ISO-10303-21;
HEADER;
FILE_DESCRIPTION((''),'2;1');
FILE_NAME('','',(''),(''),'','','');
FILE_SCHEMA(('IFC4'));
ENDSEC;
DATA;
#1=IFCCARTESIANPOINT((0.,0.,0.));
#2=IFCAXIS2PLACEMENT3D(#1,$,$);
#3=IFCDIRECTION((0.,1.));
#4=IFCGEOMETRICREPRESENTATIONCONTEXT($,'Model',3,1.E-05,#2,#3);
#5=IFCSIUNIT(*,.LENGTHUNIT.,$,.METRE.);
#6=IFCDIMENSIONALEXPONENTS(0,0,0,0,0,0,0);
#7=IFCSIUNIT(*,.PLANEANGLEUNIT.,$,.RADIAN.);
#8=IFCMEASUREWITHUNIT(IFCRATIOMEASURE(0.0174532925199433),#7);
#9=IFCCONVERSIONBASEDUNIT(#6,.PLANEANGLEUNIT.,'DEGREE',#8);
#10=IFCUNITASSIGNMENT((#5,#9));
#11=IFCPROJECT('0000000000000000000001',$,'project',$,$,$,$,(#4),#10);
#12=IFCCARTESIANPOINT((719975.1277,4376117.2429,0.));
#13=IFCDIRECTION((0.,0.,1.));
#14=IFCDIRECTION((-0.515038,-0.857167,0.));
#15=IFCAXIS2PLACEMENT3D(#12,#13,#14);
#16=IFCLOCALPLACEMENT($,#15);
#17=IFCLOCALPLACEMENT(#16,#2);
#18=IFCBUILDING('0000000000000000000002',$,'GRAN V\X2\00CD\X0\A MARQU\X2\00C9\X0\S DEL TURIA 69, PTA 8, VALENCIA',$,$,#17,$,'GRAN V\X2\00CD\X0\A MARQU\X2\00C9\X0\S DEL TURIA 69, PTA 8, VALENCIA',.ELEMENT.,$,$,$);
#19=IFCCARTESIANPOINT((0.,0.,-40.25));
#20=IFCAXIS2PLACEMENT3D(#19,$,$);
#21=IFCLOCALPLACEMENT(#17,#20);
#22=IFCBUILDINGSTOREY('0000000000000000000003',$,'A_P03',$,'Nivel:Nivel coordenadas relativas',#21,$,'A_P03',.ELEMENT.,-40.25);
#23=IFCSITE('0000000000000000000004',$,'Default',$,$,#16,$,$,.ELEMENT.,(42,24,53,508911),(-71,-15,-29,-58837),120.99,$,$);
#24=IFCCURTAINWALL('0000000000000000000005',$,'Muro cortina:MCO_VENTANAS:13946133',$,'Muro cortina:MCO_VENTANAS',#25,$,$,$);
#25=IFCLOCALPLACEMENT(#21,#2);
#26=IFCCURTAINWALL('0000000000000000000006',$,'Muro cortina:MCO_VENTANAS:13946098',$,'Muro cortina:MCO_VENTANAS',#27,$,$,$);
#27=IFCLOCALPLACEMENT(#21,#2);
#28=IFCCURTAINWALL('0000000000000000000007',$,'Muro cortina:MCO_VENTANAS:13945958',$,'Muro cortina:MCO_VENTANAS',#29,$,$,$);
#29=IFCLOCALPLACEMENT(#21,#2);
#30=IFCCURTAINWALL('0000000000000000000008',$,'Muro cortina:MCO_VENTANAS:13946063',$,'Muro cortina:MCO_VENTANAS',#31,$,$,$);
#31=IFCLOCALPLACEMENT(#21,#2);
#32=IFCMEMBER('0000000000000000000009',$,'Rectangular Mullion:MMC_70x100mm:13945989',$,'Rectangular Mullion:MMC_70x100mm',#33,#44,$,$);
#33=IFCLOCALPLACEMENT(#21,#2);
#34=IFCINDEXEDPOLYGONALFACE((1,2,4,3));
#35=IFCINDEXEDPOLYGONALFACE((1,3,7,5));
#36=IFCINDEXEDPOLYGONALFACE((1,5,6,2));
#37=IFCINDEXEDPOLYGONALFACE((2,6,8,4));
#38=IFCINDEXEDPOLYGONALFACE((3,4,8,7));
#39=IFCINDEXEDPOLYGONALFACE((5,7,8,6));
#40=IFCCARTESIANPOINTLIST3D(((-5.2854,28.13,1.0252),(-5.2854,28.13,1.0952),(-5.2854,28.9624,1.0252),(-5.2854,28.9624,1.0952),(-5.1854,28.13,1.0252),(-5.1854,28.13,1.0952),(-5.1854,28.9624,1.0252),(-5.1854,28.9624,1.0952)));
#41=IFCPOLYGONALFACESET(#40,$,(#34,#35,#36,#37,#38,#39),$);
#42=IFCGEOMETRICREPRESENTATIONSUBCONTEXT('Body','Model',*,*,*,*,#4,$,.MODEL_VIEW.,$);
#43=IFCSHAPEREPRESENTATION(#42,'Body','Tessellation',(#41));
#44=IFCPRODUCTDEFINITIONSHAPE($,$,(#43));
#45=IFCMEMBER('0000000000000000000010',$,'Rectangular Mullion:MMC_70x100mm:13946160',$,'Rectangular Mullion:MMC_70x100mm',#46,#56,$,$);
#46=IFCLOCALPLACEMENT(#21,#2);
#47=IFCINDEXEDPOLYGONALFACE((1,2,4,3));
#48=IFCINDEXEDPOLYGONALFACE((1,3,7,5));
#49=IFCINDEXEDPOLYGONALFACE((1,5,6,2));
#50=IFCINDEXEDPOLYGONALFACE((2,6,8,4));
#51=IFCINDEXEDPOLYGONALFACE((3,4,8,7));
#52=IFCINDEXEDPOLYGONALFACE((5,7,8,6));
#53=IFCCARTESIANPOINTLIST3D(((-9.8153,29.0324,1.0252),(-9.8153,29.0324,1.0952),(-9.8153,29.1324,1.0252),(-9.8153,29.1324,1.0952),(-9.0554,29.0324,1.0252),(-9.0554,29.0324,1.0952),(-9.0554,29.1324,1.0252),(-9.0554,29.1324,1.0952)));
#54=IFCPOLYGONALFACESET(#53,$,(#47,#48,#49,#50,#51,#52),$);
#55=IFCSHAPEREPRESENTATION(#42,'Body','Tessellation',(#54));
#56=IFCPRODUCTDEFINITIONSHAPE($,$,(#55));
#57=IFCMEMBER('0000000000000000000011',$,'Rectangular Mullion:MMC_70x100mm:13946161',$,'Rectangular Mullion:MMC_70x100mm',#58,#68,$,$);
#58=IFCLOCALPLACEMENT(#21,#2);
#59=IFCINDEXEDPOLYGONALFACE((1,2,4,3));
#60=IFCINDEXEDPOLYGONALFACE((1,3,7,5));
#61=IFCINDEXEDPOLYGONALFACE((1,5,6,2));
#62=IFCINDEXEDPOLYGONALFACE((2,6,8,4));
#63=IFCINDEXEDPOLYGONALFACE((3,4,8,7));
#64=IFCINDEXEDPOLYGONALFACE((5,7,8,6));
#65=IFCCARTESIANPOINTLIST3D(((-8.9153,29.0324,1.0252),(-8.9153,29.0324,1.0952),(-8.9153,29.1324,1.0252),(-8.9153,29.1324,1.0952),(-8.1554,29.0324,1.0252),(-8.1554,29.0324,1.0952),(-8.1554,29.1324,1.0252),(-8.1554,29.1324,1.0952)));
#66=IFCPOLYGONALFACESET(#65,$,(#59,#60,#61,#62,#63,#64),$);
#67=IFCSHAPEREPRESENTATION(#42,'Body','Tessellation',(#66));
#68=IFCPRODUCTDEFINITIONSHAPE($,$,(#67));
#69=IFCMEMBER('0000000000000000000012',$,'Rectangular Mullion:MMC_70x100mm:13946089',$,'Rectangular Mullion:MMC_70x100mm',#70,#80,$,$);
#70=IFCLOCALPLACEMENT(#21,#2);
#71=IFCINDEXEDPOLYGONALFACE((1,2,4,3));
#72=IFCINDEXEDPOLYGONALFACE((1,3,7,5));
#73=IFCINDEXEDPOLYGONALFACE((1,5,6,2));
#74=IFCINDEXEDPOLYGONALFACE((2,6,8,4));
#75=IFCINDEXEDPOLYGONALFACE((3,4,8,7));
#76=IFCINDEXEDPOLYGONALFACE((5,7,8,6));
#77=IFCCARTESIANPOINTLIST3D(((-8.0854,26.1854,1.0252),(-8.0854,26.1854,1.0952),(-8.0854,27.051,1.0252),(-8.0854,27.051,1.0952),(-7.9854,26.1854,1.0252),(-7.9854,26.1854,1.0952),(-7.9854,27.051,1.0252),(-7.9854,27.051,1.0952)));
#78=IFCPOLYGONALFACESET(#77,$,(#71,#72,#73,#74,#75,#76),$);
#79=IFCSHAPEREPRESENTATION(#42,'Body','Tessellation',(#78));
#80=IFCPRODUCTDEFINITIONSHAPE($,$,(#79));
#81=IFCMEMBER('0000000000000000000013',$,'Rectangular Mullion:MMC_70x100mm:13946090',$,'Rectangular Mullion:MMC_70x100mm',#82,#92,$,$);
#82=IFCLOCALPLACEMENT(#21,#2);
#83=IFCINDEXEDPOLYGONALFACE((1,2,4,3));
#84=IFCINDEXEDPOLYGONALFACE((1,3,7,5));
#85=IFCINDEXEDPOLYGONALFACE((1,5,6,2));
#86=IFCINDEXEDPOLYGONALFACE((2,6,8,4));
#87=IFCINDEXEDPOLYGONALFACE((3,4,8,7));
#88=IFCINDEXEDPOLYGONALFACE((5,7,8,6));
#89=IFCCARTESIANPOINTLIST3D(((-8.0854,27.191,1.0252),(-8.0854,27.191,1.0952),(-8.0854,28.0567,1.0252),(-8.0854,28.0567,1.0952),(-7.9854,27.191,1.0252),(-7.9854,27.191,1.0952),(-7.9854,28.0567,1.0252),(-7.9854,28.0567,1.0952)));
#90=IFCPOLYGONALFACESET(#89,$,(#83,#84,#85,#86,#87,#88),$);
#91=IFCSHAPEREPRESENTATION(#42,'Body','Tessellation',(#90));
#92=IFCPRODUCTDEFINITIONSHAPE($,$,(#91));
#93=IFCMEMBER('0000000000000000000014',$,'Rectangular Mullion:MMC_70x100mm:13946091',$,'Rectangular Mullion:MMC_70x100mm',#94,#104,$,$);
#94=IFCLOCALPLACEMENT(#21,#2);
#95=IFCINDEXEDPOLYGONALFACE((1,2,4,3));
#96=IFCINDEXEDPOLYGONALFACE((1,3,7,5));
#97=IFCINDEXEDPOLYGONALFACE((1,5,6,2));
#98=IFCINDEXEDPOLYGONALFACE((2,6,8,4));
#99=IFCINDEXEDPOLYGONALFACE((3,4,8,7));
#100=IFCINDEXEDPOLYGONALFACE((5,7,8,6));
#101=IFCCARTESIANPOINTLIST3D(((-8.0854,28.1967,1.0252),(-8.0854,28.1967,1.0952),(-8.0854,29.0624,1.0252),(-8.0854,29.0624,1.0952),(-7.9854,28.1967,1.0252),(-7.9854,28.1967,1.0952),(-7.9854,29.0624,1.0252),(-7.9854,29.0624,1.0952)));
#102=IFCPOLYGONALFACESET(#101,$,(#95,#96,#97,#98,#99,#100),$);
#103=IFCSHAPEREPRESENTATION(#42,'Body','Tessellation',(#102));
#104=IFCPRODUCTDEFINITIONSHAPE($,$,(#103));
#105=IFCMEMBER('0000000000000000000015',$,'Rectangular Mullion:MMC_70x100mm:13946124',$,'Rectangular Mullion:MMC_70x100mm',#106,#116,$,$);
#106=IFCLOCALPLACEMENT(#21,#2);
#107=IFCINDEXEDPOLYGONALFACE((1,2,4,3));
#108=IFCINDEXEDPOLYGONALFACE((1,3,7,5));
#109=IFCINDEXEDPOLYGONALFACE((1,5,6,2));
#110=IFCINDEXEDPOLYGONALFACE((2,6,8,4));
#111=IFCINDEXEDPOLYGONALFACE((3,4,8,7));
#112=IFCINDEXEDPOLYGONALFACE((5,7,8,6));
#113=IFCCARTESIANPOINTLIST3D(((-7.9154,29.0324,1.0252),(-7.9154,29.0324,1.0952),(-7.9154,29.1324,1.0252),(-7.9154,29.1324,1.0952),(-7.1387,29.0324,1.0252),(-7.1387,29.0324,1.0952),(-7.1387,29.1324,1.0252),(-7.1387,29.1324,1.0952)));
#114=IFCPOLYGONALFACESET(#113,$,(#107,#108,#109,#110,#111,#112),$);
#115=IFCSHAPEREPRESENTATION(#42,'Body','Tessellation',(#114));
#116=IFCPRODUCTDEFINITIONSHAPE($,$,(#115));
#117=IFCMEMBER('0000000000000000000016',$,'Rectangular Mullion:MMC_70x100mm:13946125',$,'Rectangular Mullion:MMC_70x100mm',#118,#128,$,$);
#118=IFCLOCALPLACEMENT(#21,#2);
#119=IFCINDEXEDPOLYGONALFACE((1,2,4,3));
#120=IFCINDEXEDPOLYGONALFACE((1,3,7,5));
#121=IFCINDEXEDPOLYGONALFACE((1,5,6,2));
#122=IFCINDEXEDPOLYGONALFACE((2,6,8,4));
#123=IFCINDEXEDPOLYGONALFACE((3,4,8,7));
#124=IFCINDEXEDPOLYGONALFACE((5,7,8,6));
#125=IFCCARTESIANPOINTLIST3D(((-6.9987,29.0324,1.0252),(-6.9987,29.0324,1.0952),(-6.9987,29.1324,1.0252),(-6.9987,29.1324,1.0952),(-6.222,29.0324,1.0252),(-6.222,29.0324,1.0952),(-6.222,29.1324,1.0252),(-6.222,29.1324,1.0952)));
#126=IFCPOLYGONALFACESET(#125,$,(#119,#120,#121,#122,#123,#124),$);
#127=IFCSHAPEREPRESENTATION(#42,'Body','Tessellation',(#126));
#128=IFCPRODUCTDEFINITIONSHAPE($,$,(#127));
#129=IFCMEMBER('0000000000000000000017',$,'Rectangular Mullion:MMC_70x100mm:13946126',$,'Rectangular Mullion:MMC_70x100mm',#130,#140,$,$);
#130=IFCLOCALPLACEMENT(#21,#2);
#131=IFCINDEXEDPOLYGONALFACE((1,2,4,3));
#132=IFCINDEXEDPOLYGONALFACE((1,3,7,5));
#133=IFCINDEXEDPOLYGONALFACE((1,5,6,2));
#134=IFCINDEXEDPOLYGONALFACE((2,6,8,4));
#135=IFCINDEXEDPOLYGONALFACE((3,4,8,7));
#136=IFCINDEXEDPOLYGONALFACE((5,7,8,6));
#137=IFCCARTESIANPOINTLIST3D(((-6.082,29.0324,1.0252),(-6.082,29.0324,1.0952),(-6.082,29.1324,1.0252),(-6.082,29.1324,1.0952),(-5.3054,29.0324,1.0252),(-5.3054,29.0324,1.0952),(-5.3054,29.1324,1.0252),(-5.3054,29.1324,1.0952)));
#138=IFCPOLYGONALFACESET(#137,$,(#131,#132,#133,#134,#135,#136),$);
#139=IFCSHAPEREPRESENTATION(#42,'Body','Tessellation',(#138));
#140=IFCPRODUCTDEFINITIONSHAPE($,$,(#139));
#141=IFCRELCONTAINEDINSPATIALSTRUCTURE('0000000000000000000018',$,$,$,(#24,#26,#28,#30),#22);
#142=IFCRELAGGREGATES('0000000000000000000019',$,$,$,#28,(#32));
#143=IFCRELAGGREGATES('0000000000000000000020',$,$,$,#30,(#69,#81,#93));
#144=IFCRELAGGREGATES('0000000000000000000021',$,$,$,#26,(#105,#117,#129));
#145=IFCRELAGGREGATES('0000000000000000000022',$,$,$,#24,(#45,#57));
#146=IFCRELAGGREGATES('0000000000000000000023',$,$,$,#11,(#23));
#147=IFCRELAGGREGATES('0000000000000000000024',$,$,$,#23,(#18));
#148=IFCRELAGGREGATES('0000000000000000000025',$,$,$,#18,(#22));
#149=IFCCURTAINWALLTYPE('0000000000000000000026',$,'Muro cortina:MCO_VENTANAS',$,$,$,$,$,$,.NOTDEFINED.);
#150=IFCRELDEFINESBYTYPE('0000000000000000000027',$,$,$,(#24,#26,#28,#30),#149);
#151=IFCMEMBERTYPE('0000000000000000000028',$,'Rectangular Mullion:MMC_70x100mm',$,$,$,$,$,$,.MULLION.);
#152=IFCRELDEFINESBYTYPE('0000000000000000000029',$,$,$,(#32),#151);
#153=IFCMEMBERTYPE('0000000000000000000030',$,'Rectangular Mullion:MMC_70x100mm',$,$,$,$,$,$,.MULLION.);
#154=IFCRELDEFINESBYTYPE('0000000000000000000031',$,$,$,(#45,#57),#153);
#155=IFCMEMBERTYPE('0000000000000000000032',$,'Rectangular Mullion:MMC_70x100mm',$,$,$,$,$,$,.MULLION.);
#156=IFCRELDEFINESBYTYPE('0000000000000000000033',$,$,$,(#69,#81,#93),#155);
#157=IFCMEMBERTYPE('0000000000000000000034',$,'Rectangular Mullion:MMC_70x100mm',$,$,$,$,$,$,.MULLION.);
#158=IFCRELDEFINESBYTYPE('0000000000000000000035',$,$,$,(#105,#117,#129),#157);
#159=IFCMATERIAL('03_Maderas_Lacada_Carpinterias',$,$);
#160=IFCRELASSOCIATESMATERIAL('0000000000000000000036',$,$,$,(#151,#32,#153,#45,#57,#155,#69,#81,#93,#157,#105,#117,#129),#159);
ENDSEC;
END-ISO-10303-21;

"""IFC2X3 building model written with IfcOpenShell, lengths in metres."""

from ifc_helpers import new_model, entity, si_unit, converted_unit, direction, frame, origin, origin_2d_with_axis, place, context, subcontext, project, spatial, rectangle, extrude, source, transform, mapped, material, type_object, type_shapes, element, aggregate, save


model = new_model("IFC2X3")

# Units and contexts
model_context = context("Model", 3, precision=1e-05, world=origin(), true_north=direction((0.0, 1.0)))
body_context = subcontext(model_context, "Body", "Model", "MODEL_VIEW")
ifc_project = project(units=[si_unit("LENGTHUNIT", "METRE"), converted_unit("PLANEANGLEUNIT", "DEGREE", entity("IfcRatioMeasure", 0.0174532925199433), si_unit("PLANEANGLEUNIT", "RADIAN"), dimensions=[0, 0, 0, 0, 0, 0, 0])], contexts=[model_context])

# Site, building, storey
site_placement = place(None, frame((719975.1277, 4376117.2429, 0.0), z_axis=(0.0, 0.0, 1.0), x_axis=(-0.515038, -0.857167, 0.0)))
site = spatial("IfcSite", under=ifc_project, at=site_placement, Name="Default", CompositionType="ELEMENT", RefLatitude=(42, 24, 53, 508911), RefLongitude=(-71, -15, -29, -58837), RefElevation=120.99)
building_placement = place(site_placement, origin())
building = spatial("IfcBuilding", under=site, at=building_placement, Name="GRAN VÍA MARQUÉS DEL TURIA 69, PTA 8, VALENCIA", LongName="GRAN VÍA MARQUÉS DEL TURIA 69, PTA 8, VALENCIA", CompositionType="ELEMENT")
storey_placement = place(building_placement, frame((0.0, 0.0, -40.25)))
storey = spatial("IfcBuildingStorey", under=building, at=storey_placement, Name="A_P03", ObjectType="Nivel:Nivel coordenadas relativas", LongName="A_P03", CompositionType="ELEMENT", Elevation=-40.25)

# Curtain wall
curtain_wall_type = type_object("IfcCurtainWallType", Name="Muro cortina:MCO_VENTANAS", PredefinedType="NOTDEFINED")
curtain_wall_1_placement = place(storey_placement, frame((0.0, 0.0, 40.25)))
curtain_wall_1 = element("IfcCurtainWall", 1, at=curtain_wall_1_placement, inside=storey, type_object=curtain_wall_type, Name="Muro cortina:MCO_VENTANAS:13946133", ObjectType="Muro cortina:MCO_VENTANAS")
ifc_material_1 = material(Name="03_Maderas_Lacada_Carpinterias")

# Curtain walls
curtain_wall_2_placement = place(storey_placement, frame((0.0, 0.0, 40.25)))
curtain_wall_2 = element("IfcCurtainWall", 2, at=curtain_wall_2_placement, inside=storey, type_object=curtain_wall_type, Name="Muro cortina:MCO_VENTANAS:13946098", ObjectType="Muro cortina:MCO_VENTANAS")
curtain_wall_3_placement = place(storey_placement, frame((0.0, 0.0, 40.25)))
curtain_wall_3 = element("IfcCurtainWall", 3, at=curtain_wall_3_placement, inside=storey, type_object=curtain_wall_type, Name="Muro cortina:MCO_VENTANAS:13945958", ObjectType="Muro cortina:MCO_VENTANAS")

# Curtain wall
curtain_wall_4_placement = place(storey_placement, frame((0.0, 0.0, 40.25)))
curtain_wall_4 = element("IfcCurtainWall", 4, at=curtain_wall_4_placement, inside=storey, type_object=curtain_wall_type, Name="Muro cortina:MCO_VENTANAS:13946063", ObjectType="Muro cortina:MCO_VENTANAS")

# Members
member_type_1 = type_object("IfcMemberType", Name="Rectangular Mullion:MMC_70x100mm", PredefinedType="MULLION", material=ifc_material_1)
shared_shape_1 = source(origin(), body_context, "Body", "SweptSolid", [
    extrude(rectangle(XDim=0.1, YDim=0.07, at=origin_2d_with_axis()), frame((0.0, 0.0, -0.8323), z_axis=(0.0, 0.0, 1.0), x_axis=(0.0, -1.0, 0.0)), (0.0, 0.0, 1.0), 0.8323),
])
type_shapes(member_type_1, [shared_shape_1])
member_1_placement = place(storey_placement, frame((-5.2354, 28.9624, 1.0602), z_axis=(0.0, 1.0, 0.0), x_axis=(0.0, 0.0, 1.0)))
member_1 = element("IfcMember", 5, at=member_1_placement, type_object=member_type_1, material=ifc_material_1, Name="Rectangular Mullion:MMC_70x100mm:13945989", ObjectType="Rectangular Mullion:MMC_70x100mm", context=body_context, shape_type="MappedRepresentation", body=[
    mapped(shared_shape_1, transform((0.0, 0.0, 0.0), scale=1.0)),
])
member_type_2 = type_object("IfcMemberType", Name="Rectangular Mullion:MMC_70x100mm", PredefinedType="MULLION", material=ifc_material_1)
shared_shape_2 = source(origin(), body_context, "Body", "SweptSolid", [
    extrude(rectangle(XDim=0.1, YDim=0.07, at=origin_2d_with_axis()), frame((0.0, 0.0, -0.76), z_axis=(0.0, 0.0, 1.0), x_axis=(0.0, -1.0, 0.0)), (0.0, 0.0, 1.0), 0.76),
])
type_shapes(member_type_2, [shared_shape_2])
member_2_placement = place(storey_placement, frame((-9.0554, 29.0824, 1.0602), z_axis=(1.0, 0.0, 0.0), x_axis=(0.0, 0.0, 1.0)))
member_2 = element("IfcMember", 6, at=member_2_placement, type_object=member_type_2, material=ifc_material_1, Name="Rectangular Mullion:MMC_70x100mm:13946160", ObjectType="Rectangular Mullion:MMC_70x100mm", context=body_context, shape_type="MappedRepresentation", body=[
    mapped(shared_shape_2, transform((0.0, 0.0, 0.0), scale=1.0)),
])
member_3_placement = place(storey_placement, frame((-8.1554, 29.0824, 1.0602), z_axis=(1.0, 0.0, 0.0), x_axis=(0.0, 0.0, 1.0)))
member_3 = element("IfcMember", 7, at=member_3_placement, type_object=member_type_2, material=ifc_material_1, Name="Rectangular Mullion:MMC_70x100mm:13946161", ObjectType="Rectangular Mullion:MMC_70x100mm", context=body_context, shape_type="MappedRepresentation", body=[
    mapped(shared_shape_2, transform((0.0, 0.0, 0.0), scale=1.0)),
])
member_type_3 = type_object("IfcMemberType", Name="Rectangular Mullion:MMC_70x100mm", PredefinedType="MULLION", material=ifc_material_1)
shared_shape_3 = source(origin(), body_context, "Body", "SweptSolid", [
    extrude(rectangle(XDim=0.1, YDim=0.07, at=origin_2d_with_axis()), frame((0.0, 0.0, -0.8657), z_axis=(0.0, 0.0, 1.0), x_axis=(0.0, -1.0, 0.0)), (0.0, 0.0, 1.0), 0.8657),
])
type_shapes(member_type_3, [shared_shape_3])
member_4_placement = place(storey_placement, frame((-8.0354, 27.051, 1.0602), z_axis=(0.0, 1.0, 0.0), x_axis=(0.0, 0.0, 1.0)))
member_4 = element("IfcMember", 8, at=member_4_placement, type_object=member_type_3, material=ifc_material_1, Name="Rectangular Mullion:MMC_70x100mm:13946089", ObjectType="Rectangular Mullion:MMC_70x100mm", context=body_context, shape_type="MappedRepresentation", body=[
    mapped(shared_shape_3, transform((0.0, 0.0, 0.0), scale=1.0)),
])
member_5_placement = place(storey_placement, frame((-8.0354, 28.0567, 1.0602), z_axis=(0.0, 1.0, 0.0), x_axis=(0.0, 0.0, 1.0)))
member_5 = element("IfcMember", 9, at=member_5_placement, type_object=member_type_3, material=ifc_material_1, Name="Rectangular Mullion:MMC_70x100mm:13946090", ObjectType="Rectangular Mullion:MMC_70x100mm", context=body_context, shape_type="MappedRepresentation", body=[
    mapped(shared_shape_3, transform((0.0, 0.0, 0.0), scale=1.0)),
])
member_6_placement = place(storey_placement, frame((-8.0354, 29.0624, 1.0602), z_axis=(0.0, 1.0, 0.0), x_axis=(0.0, 0.0, 1.0)))
member_6 = element("IfcMember", 10, at=member_6_placement, type_object=member_type_3, material=ifc_material_1, Name="Rectangular Mullion:MMC_70x100mm:13946091", ObjectType="Rectangular Mullion:MMC_70x100mm", context=body_context, shape_type="MappedRepresentation", body=[
    mapped(shared_shape_3, transform((0.0, 0.0, 0.0), scale=1.0)),
])
member_type_4 = type_object("IfcMemberType", Name="Rectangular Mullion:MMC_70x100mm", PredefinedType="MULLION", material=ifc_material_1)
shared_shape_4 = source(origin(), body_context, "Body", "SweptSolid", [
    extrude(rectangle(XDim=0.1, YDim=0.07, at=origin_2d_with_axis()), frame((0.0, 0.0, -0.7767), z_axis=(0.0, 0.0, 1.0), x_axis=(0.0, -1.0, 0.0)), (0.0, 0.0, 1.0), 0.7767),
])
type_shapes(member_type_4, [shared_shape_4])
member_7_placement = place(storey_placement, frame((-7.1387, 29.0824, 1.0602), z_axis=(1.0, 0.0, 0.0), x_axis=(0.0, 0.0, 1.0)))
member_7 = element("IfcMember", 11, at=member_7_placement, type_object=member_type_4, material=ifc_material_1, Name="Rectangular Mullion:MMC_70x100mm:13946124", ObjectType="Rectangular Mullion:MMC_70x100mm", context=body_context, shape_type="MappedRepresentation", body=[
    mapped(shared_shape_4, transform((0.0, 0.0, 0.0), scale=1.0)),
])
member_8_placement = place(storey_placement, frame((-6.222, 29.0824, 1.0602), z_axis=(1.0, 0.0, 0.0), x_axis=(0.0, 0.0, 1.0)))
member_8 = element("IfcMember", 12, at=member_8_placement, type_object=member_type_4, material=ifc_material_1, Name="Rectangular Mullion:MMC_70x100mm:13946125", ObjectType="Rectangular Mullion:MMC_70x100mm", context=body_context, shape_type="MappedRepresentation", body=[
    mapped(shared_shape_4, transform((0.0, 0.0, 0.0), scale=1.0)),
])
member_9_placement = place(storey_placement, frame((-5.3054, 29.0824, 1.0602), z_axis=(1.0, 0.0, 0.0), x_axis=(0.0, 0.0, 1.0)))
member_9 = element("IfcMember", 13, at=member_9_placement, type_object=member_type_4, material=ifc_material_1, Name="Rectangular Mullion:MMC_70x100mm:13946126", ObjectType="Rectangular Mullion:MMC_70x100mm", context=body_context, shape_type="MappedRepresentation", body=[
    mapped(shared_shape_4, transform((0.0, 0.0, 0.0), scale=1.0)),
])

aggregate(curtain_wall_3, [member_1])
aggregate(curtain_wall_4, [member_4, member_5, member_6])
aggregate(curtain_wall_2, [member_7, member_8, member_9])
aggregate(curtain_wall_1, [member_2, member_3])

save(model, "model.ifc")
